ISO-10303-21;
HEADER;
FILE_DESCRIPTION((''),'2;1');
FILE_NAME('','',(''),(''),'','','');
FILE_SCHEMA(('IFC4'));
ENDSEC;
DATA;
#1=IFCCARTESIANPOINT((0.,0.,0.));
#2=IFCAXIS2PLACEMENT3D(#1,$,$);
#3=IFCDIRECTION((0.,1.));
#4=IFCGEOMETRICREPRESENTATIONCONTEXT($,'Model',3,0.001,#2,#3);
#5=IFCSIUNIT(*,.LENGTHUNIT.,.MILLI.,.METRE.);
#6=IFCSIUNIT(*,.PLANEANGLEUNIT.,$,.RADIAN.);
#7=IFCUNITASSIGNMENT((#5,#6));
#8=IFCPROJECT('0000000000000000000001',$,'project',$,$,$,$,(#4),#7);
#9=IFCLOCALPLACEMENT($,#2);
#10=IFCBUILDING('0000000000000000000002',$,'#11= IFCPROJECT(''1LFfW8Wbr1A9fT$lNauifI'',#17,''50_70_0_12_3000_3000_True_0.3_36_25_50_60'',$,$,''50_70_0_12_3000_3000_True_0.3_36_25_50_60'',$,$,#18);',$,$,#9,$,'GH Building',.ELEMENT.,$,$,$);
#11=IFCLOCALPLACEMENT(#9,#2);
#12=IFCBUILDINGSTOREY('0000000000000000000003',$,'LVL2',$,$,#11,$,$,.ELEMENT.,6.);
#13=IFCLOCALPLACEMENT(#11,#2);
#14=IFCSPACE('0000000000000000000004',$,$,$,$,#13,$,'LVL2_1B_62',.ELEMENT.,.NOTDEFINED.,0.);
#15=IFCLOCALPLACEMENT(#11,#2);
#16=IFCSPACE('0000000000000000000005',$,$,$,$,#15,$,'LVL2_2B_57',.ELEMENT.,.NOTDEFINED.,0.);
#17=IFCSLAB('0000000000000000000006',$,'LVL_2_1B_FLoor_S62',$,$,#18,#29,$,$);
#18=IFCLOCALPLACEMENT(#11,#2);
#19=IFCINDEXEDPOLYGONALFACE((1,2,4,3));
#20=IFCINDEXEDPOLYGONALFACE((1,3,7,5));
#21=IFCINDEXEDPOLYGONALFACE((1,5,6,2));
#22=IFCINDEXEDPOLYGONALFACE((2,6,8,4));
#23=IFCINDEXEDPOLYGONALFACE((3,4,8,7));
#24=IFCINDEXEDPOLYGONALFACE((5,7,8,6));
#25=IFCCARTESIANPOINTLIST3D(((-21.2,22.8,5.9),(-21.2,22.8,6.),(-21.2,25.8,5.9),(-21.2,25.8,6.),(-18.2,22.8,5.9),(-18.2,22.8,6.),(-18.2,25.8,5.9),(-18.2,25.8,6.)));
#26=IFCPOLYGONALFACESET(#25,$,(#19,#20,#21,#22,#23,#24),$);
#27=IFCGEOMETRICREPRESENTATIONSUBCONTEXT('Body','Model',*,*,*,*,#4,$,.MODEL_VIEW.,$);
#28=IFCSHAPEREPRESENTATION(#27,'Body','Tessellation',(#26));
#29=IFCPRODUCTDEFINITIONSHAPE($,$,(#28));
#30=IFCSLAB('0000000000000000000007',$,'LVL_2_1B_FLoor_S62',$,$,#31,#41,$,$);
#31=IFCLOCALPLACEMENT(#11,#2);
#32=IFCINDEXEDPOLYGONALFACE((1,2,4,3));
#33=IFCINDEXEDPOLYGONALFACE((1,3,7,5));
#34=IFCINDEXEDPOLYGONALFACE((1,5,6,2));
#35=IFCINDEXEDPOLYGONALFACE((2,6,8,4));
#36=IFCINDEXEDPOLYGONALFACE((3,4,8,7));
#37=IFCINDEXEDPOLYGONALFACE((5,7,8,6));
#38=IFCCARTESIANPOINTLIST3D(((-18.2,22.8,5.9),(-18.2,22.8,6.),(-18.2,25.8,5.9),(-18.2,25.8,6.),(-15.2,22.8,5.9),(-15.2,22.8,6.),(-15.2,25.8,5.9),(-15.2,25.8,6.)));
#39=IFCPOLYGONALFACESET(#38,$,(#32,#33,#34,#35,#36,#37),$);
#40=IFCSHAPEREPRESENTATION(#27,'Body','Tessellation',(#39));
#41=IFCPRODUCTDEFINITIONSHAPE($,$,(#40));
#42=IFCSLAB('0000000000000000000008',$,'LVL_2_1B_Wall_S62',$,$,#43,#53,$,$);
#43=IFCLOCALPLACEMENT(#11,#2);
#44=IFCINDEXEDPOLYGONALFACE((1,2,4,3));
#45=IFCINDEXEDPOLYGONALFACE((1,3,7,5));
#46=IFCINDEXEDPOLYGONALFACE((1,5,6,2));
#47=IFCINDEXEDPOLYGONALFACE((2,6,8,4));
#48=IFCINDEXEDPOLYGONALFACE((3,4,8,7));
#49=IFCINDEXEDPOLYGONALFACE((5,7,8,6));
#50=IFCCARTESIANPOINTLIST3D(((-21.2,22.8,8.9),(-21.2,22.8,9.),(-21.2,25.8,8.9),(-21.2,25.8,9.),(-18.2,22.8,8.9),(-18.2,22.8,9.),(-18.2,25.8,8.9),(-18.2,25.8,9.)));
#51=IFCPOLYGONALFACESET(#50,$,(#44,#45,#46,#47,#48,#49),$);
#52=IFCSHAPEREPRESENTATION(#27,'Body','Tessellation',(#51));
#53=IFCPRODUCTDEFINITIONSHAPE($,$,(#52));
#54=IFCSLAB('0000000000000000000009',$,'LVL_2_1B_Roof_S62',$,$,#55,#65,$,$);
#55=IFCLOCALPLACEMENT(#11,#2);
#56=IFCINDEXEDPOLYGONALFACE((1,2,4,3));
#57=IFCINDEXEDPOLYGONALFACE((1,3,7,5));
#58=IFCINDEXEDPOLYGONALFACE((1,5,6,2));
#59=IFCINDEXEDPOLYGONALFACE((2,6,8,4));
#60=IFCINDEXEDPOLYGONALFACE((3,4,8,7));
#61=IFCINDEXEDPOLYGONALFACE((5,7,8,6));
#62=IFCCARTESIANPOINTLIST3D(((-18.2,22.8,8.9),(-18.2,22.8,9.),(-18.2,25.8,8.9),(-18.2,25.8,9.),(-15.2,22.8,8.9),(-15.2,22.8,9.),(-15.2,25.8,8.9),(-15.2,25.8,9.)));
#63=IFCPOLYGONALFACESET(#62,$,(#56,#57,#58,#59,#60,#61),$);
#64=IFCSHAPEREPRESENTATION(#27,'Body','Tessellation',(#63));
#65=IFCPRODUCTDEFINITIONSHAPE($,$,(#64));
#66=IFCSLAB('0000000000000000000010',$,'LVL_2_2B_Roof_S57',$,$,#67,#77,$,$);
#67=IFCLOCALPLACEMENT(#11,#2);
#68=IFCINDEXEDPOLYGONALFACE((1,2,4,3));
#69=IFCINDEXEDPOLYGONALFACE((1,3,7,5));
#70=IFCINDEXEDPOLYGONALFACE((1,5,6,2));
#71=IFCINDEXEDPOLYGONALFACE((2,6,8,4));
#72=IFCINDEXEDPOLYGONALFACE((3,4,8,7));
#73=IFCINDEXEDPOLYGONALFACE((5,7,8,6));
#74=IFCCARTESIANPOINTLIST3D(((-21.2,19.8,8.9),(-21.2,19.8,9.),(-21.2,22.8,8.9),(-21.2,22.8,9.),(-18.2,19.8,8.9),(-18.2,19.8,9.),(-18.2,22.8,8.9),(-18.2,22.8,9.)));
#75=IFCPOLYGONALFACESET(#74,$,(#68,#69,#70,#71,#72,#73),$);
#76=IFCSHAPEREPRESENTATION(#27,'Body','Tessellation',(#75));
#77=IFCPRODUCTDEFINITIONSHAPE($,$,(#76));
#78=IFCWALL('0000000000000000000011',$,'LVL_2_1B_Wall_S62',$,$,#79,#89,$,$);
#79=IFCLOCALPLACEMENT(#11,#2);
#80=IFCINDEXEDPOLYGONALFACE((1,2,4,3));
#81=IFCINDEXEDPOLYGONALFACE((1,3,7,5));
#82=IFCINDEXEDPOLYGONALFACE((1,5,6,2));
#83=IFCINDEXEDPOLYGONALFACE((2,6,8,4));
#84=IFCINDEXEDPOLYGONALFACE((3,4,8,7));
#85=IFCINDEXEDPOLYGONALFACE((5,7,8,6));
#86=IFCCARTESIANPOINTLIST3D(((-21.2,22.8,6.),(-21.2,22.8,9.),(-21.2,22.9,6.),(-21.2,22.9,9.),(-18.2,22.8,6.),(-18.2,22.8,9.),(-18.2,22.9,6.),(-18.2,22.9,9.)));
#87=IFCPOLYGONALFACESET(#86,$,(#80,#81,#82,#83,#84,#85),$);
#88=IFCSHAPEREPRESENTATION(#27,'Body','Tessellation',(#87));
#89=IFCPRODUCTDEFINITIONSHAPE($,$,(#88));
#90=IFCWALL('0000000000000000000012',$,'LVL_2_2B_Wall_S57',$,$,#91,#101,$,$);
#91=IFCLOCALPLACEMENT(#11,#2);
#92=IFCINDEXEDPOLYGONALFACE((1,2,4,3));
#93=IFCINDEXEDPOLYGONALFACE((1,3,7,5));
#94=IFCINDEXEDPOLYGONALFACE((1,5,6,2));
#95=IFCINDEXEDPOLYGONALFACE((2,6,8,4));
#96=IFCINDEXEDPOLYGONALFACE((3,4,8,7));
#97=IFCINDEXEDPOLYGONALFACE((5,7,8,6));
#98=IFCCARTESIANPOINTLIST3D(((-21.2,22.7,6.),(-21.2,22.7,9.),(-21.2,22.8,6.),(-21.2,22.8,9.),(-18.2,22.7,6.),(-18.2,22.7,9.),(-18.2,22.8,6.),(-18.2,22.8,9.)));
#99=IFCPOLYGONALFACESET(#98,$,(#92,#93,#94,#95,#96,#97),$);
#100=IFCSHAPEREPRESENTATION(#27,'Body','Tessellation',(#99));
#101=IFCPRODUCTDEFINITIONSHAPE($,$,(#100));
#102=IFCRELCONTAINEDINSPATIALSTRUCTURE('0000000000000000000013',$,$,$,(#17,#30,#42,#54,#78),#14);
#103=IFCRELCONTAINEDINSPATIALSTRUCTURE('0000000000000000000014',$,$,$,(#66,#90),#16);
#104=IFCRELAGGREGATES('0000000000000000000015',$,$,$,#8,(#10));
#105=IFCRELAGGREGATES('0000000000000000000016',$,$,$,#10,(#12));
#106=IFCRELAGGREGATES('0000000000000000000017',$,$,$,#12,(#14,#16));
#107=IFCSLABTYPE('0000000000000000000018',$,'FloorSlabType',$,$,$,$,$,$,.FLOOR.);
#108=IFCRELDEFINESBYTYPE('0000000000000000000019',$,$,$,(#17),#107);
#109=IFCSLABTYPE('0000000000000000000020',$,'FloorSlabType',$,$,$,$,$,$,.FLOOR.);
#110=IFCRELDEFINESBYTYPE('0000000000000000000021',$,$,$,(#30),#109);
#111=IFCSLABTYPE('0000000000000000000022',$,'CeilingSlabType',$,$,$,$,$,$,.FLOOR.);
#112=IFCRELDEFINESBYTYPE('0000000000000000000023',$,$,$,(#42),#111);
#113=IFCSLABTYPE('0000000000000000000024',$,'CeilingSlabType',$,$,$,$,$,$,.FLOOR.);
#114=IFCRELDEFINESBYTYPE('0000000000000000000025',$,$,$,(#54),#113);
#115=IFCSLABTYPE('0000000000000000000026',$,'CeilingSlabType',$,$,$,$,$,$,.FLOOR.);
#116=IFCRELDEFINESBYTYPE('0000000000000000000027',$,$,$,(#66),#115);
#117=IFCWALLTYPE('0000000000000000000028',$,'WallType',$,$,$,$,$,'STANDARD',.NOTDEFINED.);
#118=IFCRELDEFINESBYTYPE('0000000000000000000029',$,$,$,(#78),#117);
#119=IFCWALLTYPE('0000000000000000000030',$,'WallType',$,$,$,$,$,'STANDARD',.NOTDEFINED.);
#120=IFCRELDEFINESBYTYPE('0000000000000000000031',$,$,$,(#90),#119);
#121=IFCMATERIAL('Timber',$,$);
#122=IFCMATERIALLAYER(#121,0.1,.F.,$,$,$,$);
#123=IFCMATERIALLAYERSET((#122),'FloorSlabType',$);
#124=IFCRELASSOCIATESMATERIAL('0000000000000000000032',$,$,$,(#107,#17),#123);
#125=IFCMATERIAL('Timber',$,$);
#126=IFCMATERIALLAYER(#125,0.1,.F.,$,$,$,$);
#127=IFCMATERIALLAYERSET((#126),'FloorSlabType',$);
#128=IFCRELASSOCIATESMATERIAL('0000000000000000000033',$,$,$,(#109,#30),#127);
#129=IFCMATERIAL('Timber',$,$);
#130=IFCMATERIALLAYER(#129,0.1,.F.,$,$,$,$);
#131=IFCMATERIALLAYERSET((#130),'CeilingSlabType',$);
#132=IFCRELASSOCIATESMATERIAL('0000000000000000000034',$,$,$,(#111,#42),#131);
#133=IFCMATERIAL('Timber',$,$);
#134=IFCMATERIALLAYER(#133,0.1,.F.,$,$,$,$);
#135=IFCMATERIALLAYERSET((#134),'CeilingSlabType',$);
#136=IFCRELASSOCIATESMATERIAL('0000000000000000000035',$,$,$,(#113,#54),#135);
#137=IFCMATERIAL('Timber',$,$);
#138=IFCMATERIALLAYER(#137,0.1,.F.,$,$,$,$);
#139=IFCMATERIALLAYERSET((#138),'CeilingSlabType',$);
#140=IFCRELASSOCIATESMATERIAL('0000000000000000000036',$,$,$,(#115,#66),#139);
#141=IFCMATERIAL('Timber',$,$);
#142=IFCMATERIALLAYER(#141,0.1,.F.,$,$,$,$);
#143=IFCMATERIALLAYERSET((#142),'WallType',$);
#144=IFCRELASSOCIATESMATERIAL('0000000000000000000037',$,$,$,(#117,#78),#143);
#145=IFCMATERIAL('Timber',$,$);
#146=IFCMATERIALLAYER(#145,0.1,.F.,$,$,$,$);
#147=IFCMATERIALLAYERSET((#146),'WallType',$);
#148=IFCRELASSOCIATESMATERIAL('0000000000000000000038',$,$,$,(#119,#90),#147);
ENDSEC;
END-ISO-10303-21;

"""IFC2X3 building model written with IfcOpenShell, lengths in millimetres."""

from ifc_helpers import new_model, si_unit, direction, frame, frame_2d, origin, place, context, subcontext, project, spatial, rectangle, extrude, material, layer, layer_set, layer_usage, type_object, element, save


model = new_model("IFC2X3")

# Units and contexts
model_context = context("Model", 3, precision=0.001, world=origin(), true_north=direction((0.0, 1.0)))
body_context = subcontext(model_context, "Body", "Model", "MODEL_VIEW")
ifc_project = project(units=[si_unit("LENGTHUNIT", "METRE", prefix="MILLI"), si_unit("PLANEANGLEUNIT", "RADIAN")], contexts=[model_context])

# Building, storey
building_placement = place(None, origin())
building = spatial("IfcBuilding", under=ifc_project, at=building_placement, Name="#11= IFCPROJECT('1LFfW8Wbr1A9fT$lNauifI',#17,'50_70_0_12_3000_3000_True_0.3_36_25_50_60',$,$,'50_70_0_12_3000_3000_True_0.3_36_25_50_60',$,$,#18);", LongName="GH Building", CompositionType="ELEMENT")
storey_placement = place(building_placement, origin())
storey = spatial("IfcBuildingStorey", under=building, at=storey_placement, Name="LVL2", CompositionType="ELEMENT", Elevation=6.0)

# Shared definitions
space_1_placement = place(storey_placement, origin())
space_1 = spatial("IfcSpace", under=storey, at=space_1_placement, LongName="LVL2_1B_62", CompositionType="ELEMENT", InteriorOrExteriorSpace="NOTDEFINED", ElevationWithFlooring=0.0)

# Slabs
ifc_material_1 = material(Name="Timber")
ifc_layer_1 = layer(ifc_material_1, 0.1, ventilated=False)
ifc_layer_set_1 = layer_set([ifc_layer_1], Name="FloorSlabType")
ifc_layer_usage_1 = layer_usage(ifc_layer_set_1, "AXIS3", "NEGATIVE", -0.1)
slab_type_1 = type_object("IfcSlabType", Name="FloorSlabType", PredefinedType="FLOOR", material=ifc_layer_set_1)
slab_1_placement = place(space_1_placement, frame((-21.2, 22.8, 5.9)))
element("IfcSlab", 1, at=slab_1_placement, inside=space_1, type_object=slab_type_1, material=ifc_layer_usage_1, Name="LVL_2_1B_FLoor_S62", context=body_context, shape_type="SweptSolid", body=[
    extrude(rectangle(XDim=3.0, YDim=3.0, at=frame_2d((1.5, 1.5))), origin(), (0.0, 0.0, 1.0), 0.1),
])
ifc_material_2 = material(Name="Timber")
ifc_layer_2 = layer(ifc_material_2, 0.1, ventilated=False)
ifc_layer_set_2 = layer_set([ifc_layer_2], Name="FloorSlabType")
ifc_layer_usage_2 = layer_usage(ifc_layer_set_2, "AXIS3", "NEGATIVE", -0.1)
slab_type_2 = type_object("IfcSlabType", Name="FloorSlabType", PredefinedType="FLOOR", material=ifc_layer_set_2)
slab_2_placement = place(space_1_placement, frame((-18.2, 22.8, 5.9)))
element("IfcSlab", 2, at=slab_2_placement, inside=space_1, type_object=slab_type_2, material=ifc_layer_usage_2, Name="LVL_2_1B_FLoor_S62", context=body_context, shape_type="SweptSolid", body=[
    extrude(rectangle(XDim=3.0, YDim=3.0, at=frame_2d((1.5, 1.5))), origin(), (0.0, 0.0, 1.0), 0.1),
])
ifc_material_3 = material(Name="Timber")
ifc_layer_3 = layer(ifc_material_3, 0.1, ventilated=False)
ifc_layer_set_3 = layer_set([ifc_layer_3], Name="CeilingSlabType")
ifc_layer_usage_3 = layer_usage(ifc_layer_set_3, "AXIS3", "NEGATIVE", -0.1)
slab_type_3 = type_object("IfcSlabType", Name="CeilingSlabType", PredefinedType="FLOOR", material=ifc_layer_set_3)
slab_3_placement = place(space_1_placement, frame((-21.2, 22.8, 8.9)))
element("IfcSlab", 3, at=slab_3_placement, inside=space_1, type_object=slab_type_3, material=ifc_layer_usage_3, Name="LVL_2_1B_Wall_S62", context=body_context, shape_type="SweptSolid", body=[
    extrude(rectangle(XDim=3.0, YDim=3.0, at=frame_2d((1.5, 1.5))), origin(), (0.0, 0.0, 1.0), 0.1),
])
ifc_material_4 = material(Name="Timber")
ifc_layer_4 = layer(ifc_material_4, 0.1, ventilated=False)
ifc_layer_set_4 = layer_set([ifc_layer_4], Name="CeilingSlabType")
ifc_layer_usage_4 = layer_usage(ifc_layer_set_4, "AXIS3", "NEGATIVE", -0.1)
slab_type_4 = type_object("IfcSlabType", Name="CeilingSlabType", PredefinedType="FLOOR", material=ifc_layer_set_4)
slab_4_placement = place(space_1_placement, frame((-18.2, 22.8, 8.9)))
element("IfcSlab", 4, at=slab_4_placement, inside=space_1, type_object=slab_type_4, material=ifc_layer_usage_4, Name="LVL_2_1B_Roof_S62", context=body_context, shape_type="SweptSolid", body=[
    extrude(rectangle(XDim=3.0, YDim=3.0, at=frame_2d((1.5, 1.5))), origin(), (0.0, 0.0, 1.0), 0.1),
])

# Shared definitions
space_2_placement = place(storey_placement, origin())
space_2 = spatial("IfcSpace", under=storey, at=space_2_placement, LongName="LVL2_2B_57", CompositionType="ELEMENT", InteriorOrExteriorSpace="NOTDEFINED", ElevationWithFlooring=0.0)

# Slab
ifc_material_5 = material(Name="Timber")
ifc_layer_5 = layer(ifc_material_5, 0.1, ventilated=False)
ifc_layer_set_5 = layer_set([ifc_layer_5], Name="CeilingSlabType")
ifc_layer_usage_5 = layer_usage(ifc_layer_set_5, "AXIS3", "NEGATIVE", -0.1)
slab_type_5 = type_object("IfcSlabType", Name="CeilingSlabType", PredefinedType="FLOOR", material=ifc_layer_set_5)
slab_5_placement = place(space_2_placement, frame((-21.2, 19.8, 8.9)))
element("IfcSlab", 5, at=slab_5_placement, inside=space_2, type_object=slab_type_5, material=ifc_layer_usage_5, Name="LVL_2_2B_Roof_S57", context=body_context, shape_type="SweptSolid", body=[
    extrude(rectangle(XDim=3.0, YDim=3.0, at=frame_2d((1.5, 1.5))), origin(), (0.0, 0.0, 1.0), 0.1),
])

# Wall
ifc_material_6 = material(Name="Timber")
ifc_layer_6 = layer(ifc_material_6, 0.1, ventilated=False)
ifc_layer_set_6 = layer_set([ifc_layer_6], Name="WallType")
ifc_layer_usage_6 = layer_usage(ifc_layer_set_6, "AXIS2", "NEGATIVE", 0.0)
wall_type_1 = type_object("IfcWallType", Name="WallType", ElementType="STANDARD", PredefinedType="NOTDEFINED", material=ifc_layer_set_6)
wall_1_placement = place(space_1_placement, frame((-18.2, 22.8, 6.0), z_axis=(0.0, 0.0, 1.0), x_axis=(-1.0, 0.0, 0.0)))
element("IfcWall", 6, at=wall_1_placement, inside=space_1, type_object=wall_type_1, material=ifc_layer_usage_6, Name="LVL_2_1B_Wall_S62", context=body_context, shape_type="SweptSolid", body=[
    extrude(rectangle(XDim=3.0, YDim=0.1, at=frame_2d((1.5, -0.1))), origin(), (0.0, 0.0, 1.0), 3.0),
])

# Wall
ifc_material_7 = material(Name="Timber")
ifc_layer_7 = layer(ifc_material_7, 0.1, ventilated=False)
ifc_layer_set_7 = layer_set([ifc_layer_7], Name="WallType")
ifc_layer_usage_7 = layer_usage(ifc_layer_set_7, "AXIS2", "NEGATIVE", 0.0)
wall_type_2 = type_object("IfcWallType", Name="WallType", ElementType="STANDARD", PredefinedType="NOTDEFINED", material=ifc_layer_set_7)
wall_2_placement = place(space_2_placement, frame((-21.2, 22.8, 6.0)))
element("IfcWall", 7, at=wall_2_placement, inside=space_2, type_object=wall_type_2, material=ifc_layer_usage_7, Name="LVL_2_2B_Wall_S57", context=body_context, shape_type="SweptSolid", body=[
    extrude(rectangle(XDim=3.0, YDim=0.1, at=frame_2d((1.5, -0.1))), origin(), (0.0, 0.0, 1.0), 3.0),
])

save(model, "model.ifc")
